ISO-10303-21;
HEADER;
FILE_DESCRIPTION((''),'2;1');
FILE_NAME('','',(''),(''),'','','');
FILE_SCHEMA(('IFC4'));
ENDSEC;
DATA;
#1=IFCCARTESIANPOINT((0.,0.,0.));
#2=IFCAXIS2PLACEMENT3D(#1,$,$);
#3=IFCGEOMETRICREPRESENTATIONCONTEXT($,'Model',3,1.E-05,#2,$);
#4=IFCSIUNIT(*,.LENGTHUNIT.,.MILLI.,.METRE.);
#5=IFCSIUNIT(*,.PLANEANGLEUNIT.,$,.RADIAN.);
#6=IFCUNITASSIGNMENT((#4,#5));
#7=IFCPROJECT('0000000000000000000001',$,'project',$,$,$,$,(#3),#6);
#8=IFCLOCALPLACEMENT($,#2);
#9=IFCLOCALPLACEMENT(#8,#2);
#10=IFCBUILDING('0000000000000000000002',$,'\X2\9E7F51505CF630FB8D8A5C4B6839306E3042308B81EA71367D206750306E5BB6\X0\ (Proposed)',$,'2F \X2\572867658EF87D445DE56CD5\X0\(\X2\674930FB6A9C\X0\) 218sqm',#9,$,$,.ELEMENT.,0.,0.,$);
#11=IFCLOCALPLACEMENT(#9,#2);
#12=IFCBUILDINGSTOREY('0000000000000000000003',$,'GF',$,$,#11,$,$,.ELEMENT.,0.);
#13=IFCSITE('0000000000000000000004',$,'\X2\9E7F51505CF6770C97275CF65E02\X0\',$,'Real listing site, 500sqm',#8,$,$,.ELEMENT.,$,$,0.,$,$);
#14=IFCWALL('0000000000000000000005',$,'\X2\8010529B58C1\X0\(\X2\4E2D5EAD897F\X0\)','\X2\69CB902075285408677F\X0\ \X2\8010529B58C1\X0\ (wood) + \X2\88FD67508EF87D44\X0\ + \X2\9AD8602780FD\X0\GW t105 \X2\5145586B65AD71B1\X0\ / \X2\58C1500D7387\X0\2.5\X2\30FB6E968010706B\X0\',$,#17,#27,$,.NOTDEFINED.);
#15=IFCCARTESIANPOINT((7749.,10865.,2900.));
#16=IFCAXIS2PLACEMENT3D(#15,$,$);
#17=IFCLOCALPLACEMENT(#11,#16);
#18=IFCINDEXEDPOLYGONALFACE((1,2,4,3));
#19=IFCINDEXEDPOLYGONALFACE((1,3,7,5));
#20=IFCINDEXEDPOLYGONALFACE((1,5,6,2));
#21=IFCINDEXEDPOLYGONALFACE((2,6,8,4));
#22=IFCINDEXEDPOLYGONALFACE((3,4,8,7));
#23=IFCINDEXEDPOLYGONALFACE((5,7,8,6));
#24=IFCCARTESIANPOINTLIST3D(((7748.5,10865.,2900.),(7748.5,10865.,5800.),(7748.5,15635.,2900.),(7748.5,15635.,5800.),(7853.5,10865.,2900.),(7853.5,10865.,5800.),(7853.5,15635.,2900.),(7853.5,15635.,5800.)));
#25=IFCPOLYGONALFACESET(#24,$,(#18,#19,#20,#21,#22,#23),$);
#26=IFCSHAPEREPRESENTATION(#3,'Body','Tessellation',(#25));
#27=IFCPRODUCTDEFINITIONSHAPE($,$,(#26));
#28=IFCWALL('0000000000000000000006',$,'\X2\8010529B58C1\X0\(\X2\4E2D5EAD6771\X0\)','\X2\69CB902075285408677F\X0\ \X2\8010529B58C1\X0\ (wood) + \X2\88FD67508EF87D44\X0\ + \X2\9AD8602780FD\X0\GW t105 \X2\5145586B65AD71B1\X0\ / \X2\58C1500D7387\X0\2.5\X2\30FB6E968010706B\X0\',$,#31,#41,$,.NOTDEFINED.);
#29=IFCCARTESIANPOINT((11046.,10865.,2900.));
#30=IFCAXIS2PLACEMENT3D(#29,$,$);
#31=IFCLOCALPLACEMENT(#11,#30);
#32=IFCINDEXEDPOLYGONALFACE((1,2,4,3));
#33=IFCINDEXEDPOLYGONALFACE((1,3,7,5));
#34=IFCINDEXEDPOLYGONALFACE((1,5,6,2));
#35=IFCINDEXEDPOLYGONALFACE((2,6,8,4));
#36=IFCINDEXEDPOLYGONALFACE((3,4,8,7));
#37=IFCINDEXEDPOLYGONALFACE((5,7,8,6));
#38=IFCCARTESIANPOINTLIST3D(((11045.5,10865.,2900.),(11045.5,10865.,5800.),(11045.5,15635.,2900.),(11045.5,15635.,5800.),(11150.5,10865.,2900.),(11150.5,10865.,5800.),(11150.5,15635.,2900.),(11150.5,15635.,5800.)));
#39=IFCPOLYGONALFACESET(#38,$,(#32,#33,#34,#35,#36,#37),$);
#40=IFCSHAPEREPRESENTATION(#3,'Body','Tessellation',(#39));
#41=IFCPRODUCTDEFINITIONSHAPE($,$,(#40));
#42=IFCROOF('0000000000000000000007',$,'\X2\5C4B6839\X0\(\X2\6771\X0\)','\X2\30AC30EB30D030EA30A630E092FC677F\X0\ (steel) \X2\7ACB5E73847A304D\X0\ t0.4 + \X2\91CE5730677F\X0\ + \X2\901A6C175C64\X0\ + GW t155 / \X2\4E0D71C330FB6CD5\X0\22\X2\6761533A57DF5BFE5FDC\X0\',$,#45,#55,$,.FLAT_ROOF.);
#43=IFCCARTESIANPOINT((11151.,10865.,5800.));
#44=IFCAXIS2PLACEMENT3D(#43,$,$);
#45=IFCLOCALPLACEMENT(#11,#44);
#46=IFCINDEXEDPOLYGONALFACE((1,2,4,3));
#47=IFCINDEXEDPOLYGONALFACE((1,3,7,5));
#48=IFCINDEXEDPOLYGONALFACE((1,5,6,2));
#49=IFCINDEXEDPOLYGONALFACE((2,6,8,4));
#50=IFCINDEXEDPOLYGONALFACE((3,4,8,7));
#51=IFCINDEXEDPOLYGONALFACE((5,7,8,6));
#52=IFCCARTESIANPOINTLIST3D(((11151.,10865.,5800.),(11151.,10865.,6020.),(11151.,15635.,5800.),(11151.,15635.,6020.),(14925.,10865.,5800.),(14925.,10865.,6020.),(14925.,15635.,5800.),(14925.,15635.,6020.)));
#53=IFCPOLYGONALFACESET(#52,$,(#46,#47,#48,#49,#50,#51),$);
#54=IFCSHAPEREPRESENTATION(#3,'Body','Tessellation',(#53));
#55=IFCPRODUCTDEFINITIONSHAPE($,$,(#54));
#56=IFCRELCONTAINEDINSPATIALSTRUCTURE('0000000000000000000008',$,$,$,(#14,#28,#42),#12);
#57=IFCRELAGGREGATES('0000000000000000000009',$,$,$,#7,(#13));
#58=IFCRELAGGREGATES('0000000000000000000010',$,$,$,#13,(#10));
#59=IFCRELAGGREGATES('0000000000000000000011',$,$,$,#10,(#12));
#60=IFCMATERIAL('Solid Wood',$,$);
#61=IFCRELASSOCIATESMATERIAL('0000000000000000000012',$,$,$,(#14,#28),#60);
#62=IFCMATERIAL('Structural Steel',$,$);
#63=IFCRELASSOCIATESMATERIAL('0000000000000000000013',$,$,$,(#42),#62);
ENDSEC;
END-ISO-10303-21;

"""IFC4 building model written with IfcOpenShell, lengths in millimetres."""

from ifc_helpers import new_model, si_unit, frame, frame_2d, origin, place, context, project, spatial, rectangle, extrude, material, element, save


model = new_model("IFC4")

# Units and contexts
model_context = context("Model", 3, precision=1e-05, world=origin())
ifc_project = project(units=[si_unit("LENGTHUNIT", "METRE", prefix="MILLI"), si_unit("PLANEANGLEUNIT", "RADIAN")], contexts=[model_context])

# Site, building, storey
site_placement = place(None, origin())
site = spatial("IfcSite", under=ifc_project, at=site_placement, Name="鹿児島県霧島市", ObjectType="Real listing site, 500sqm", CompositionType="ELEMENT", RefElevation=0.0)
building_placement = place(site_placement, origin())
building = spatial("IfcBuilding", under=site, at=building_placement, Name="鹿児島・越屋根のある自然素材の家 (Proposed)", ObjectType="2F 在来軸組工法(杉・檜) 218sqm", CompositionType="ELEMENT", ElevationOfRefHeight=0.0, ElevationOfTerrain=0.0)
storey_placement = place(building_placement, origin())
storey = spatial("IfcBuildingStorey", under=building, at=storey_placement, Name="GF", CompositionType="ELEMENT", Elevation=0.0)

# Shared definitions
ifc_material_1 = material(Name="Solid Wood")

# Walls
wall_1_placement = place(storey_placement, frame((7749.0, 10865.0, 2900.0)))
element("IfcWall", 1, at=wall_1_placement, inside=storey, material=ifc_material_1, Name="耐力壁(中庭西)", Description="構造用合板 耐力壁 (wood) + 製材軸組 + 高性能GW t105 充填断熱 / 壁倍率2.5・準耐火", PredefinedType="NOTDEFINED", context=model_context, shape_type="SweptSolid", body=[
    extrude(rectangle(XDim=105.0, YDim=4770.0, at=frame_2d((52.0, 2385.0))), frame((7749.0, 10865.0, 2900.0)), (0.0, 0.0, 1.0), 2900.0),
])
wall_2_placement = place(storey_placement, frame((11046.0, 10865.0, 2900.0)))
element("IfcWall", 2, at=wall_2_placement, inside=storey, material=ifc_material_1, Name="耐力壁(中庭東)", Description="構造用合板 耐力壁 (wood) + 製材軸組 + 高性能GW t105 充填断熱 / 壁倍率2.5・準耐火", PredefinedType="NOTDEFINED", context=model_context, shape_type="SweptSolid", body=[
    extrude(rectangle(XDim=105.0, YDim=4770.0, at=frame_2d((52.0, 2385.0))), frame((11046.0, 10865.0, 2900.0)), (0.0, 0.0, 1.0), 2900.0),
])

# Roof
ifc_material_2 = material(Name="Structural Steel")
for number, where, name in (
    (3, (11151.0, 10865.0, 5800.0), "屋根(東)"),
):
    element("IfcRoof", number, at=place(storey_placement, frame(where)), inside=storey, material=ifc_material_2, Name=name, Description="ガルバリウム鋼板 (steel) 立平葺き t0.4 + 野地板 + 通気層 + GW t155 / 不燃・法22条区域対応", PredefinedType="FLAT_ROOF", context=model_context, shape_type="SweptSolid", body=[
        extrude(rectangle(XDim=3774.0, YDim=4770.0, at=frame_2d((1887.0, 2385.0))), frame((11151.0, 10865.0, 5800.0)), (0.0, 0.0, 1.0), 220.0),
    ])

save(model, "model.ifc")
